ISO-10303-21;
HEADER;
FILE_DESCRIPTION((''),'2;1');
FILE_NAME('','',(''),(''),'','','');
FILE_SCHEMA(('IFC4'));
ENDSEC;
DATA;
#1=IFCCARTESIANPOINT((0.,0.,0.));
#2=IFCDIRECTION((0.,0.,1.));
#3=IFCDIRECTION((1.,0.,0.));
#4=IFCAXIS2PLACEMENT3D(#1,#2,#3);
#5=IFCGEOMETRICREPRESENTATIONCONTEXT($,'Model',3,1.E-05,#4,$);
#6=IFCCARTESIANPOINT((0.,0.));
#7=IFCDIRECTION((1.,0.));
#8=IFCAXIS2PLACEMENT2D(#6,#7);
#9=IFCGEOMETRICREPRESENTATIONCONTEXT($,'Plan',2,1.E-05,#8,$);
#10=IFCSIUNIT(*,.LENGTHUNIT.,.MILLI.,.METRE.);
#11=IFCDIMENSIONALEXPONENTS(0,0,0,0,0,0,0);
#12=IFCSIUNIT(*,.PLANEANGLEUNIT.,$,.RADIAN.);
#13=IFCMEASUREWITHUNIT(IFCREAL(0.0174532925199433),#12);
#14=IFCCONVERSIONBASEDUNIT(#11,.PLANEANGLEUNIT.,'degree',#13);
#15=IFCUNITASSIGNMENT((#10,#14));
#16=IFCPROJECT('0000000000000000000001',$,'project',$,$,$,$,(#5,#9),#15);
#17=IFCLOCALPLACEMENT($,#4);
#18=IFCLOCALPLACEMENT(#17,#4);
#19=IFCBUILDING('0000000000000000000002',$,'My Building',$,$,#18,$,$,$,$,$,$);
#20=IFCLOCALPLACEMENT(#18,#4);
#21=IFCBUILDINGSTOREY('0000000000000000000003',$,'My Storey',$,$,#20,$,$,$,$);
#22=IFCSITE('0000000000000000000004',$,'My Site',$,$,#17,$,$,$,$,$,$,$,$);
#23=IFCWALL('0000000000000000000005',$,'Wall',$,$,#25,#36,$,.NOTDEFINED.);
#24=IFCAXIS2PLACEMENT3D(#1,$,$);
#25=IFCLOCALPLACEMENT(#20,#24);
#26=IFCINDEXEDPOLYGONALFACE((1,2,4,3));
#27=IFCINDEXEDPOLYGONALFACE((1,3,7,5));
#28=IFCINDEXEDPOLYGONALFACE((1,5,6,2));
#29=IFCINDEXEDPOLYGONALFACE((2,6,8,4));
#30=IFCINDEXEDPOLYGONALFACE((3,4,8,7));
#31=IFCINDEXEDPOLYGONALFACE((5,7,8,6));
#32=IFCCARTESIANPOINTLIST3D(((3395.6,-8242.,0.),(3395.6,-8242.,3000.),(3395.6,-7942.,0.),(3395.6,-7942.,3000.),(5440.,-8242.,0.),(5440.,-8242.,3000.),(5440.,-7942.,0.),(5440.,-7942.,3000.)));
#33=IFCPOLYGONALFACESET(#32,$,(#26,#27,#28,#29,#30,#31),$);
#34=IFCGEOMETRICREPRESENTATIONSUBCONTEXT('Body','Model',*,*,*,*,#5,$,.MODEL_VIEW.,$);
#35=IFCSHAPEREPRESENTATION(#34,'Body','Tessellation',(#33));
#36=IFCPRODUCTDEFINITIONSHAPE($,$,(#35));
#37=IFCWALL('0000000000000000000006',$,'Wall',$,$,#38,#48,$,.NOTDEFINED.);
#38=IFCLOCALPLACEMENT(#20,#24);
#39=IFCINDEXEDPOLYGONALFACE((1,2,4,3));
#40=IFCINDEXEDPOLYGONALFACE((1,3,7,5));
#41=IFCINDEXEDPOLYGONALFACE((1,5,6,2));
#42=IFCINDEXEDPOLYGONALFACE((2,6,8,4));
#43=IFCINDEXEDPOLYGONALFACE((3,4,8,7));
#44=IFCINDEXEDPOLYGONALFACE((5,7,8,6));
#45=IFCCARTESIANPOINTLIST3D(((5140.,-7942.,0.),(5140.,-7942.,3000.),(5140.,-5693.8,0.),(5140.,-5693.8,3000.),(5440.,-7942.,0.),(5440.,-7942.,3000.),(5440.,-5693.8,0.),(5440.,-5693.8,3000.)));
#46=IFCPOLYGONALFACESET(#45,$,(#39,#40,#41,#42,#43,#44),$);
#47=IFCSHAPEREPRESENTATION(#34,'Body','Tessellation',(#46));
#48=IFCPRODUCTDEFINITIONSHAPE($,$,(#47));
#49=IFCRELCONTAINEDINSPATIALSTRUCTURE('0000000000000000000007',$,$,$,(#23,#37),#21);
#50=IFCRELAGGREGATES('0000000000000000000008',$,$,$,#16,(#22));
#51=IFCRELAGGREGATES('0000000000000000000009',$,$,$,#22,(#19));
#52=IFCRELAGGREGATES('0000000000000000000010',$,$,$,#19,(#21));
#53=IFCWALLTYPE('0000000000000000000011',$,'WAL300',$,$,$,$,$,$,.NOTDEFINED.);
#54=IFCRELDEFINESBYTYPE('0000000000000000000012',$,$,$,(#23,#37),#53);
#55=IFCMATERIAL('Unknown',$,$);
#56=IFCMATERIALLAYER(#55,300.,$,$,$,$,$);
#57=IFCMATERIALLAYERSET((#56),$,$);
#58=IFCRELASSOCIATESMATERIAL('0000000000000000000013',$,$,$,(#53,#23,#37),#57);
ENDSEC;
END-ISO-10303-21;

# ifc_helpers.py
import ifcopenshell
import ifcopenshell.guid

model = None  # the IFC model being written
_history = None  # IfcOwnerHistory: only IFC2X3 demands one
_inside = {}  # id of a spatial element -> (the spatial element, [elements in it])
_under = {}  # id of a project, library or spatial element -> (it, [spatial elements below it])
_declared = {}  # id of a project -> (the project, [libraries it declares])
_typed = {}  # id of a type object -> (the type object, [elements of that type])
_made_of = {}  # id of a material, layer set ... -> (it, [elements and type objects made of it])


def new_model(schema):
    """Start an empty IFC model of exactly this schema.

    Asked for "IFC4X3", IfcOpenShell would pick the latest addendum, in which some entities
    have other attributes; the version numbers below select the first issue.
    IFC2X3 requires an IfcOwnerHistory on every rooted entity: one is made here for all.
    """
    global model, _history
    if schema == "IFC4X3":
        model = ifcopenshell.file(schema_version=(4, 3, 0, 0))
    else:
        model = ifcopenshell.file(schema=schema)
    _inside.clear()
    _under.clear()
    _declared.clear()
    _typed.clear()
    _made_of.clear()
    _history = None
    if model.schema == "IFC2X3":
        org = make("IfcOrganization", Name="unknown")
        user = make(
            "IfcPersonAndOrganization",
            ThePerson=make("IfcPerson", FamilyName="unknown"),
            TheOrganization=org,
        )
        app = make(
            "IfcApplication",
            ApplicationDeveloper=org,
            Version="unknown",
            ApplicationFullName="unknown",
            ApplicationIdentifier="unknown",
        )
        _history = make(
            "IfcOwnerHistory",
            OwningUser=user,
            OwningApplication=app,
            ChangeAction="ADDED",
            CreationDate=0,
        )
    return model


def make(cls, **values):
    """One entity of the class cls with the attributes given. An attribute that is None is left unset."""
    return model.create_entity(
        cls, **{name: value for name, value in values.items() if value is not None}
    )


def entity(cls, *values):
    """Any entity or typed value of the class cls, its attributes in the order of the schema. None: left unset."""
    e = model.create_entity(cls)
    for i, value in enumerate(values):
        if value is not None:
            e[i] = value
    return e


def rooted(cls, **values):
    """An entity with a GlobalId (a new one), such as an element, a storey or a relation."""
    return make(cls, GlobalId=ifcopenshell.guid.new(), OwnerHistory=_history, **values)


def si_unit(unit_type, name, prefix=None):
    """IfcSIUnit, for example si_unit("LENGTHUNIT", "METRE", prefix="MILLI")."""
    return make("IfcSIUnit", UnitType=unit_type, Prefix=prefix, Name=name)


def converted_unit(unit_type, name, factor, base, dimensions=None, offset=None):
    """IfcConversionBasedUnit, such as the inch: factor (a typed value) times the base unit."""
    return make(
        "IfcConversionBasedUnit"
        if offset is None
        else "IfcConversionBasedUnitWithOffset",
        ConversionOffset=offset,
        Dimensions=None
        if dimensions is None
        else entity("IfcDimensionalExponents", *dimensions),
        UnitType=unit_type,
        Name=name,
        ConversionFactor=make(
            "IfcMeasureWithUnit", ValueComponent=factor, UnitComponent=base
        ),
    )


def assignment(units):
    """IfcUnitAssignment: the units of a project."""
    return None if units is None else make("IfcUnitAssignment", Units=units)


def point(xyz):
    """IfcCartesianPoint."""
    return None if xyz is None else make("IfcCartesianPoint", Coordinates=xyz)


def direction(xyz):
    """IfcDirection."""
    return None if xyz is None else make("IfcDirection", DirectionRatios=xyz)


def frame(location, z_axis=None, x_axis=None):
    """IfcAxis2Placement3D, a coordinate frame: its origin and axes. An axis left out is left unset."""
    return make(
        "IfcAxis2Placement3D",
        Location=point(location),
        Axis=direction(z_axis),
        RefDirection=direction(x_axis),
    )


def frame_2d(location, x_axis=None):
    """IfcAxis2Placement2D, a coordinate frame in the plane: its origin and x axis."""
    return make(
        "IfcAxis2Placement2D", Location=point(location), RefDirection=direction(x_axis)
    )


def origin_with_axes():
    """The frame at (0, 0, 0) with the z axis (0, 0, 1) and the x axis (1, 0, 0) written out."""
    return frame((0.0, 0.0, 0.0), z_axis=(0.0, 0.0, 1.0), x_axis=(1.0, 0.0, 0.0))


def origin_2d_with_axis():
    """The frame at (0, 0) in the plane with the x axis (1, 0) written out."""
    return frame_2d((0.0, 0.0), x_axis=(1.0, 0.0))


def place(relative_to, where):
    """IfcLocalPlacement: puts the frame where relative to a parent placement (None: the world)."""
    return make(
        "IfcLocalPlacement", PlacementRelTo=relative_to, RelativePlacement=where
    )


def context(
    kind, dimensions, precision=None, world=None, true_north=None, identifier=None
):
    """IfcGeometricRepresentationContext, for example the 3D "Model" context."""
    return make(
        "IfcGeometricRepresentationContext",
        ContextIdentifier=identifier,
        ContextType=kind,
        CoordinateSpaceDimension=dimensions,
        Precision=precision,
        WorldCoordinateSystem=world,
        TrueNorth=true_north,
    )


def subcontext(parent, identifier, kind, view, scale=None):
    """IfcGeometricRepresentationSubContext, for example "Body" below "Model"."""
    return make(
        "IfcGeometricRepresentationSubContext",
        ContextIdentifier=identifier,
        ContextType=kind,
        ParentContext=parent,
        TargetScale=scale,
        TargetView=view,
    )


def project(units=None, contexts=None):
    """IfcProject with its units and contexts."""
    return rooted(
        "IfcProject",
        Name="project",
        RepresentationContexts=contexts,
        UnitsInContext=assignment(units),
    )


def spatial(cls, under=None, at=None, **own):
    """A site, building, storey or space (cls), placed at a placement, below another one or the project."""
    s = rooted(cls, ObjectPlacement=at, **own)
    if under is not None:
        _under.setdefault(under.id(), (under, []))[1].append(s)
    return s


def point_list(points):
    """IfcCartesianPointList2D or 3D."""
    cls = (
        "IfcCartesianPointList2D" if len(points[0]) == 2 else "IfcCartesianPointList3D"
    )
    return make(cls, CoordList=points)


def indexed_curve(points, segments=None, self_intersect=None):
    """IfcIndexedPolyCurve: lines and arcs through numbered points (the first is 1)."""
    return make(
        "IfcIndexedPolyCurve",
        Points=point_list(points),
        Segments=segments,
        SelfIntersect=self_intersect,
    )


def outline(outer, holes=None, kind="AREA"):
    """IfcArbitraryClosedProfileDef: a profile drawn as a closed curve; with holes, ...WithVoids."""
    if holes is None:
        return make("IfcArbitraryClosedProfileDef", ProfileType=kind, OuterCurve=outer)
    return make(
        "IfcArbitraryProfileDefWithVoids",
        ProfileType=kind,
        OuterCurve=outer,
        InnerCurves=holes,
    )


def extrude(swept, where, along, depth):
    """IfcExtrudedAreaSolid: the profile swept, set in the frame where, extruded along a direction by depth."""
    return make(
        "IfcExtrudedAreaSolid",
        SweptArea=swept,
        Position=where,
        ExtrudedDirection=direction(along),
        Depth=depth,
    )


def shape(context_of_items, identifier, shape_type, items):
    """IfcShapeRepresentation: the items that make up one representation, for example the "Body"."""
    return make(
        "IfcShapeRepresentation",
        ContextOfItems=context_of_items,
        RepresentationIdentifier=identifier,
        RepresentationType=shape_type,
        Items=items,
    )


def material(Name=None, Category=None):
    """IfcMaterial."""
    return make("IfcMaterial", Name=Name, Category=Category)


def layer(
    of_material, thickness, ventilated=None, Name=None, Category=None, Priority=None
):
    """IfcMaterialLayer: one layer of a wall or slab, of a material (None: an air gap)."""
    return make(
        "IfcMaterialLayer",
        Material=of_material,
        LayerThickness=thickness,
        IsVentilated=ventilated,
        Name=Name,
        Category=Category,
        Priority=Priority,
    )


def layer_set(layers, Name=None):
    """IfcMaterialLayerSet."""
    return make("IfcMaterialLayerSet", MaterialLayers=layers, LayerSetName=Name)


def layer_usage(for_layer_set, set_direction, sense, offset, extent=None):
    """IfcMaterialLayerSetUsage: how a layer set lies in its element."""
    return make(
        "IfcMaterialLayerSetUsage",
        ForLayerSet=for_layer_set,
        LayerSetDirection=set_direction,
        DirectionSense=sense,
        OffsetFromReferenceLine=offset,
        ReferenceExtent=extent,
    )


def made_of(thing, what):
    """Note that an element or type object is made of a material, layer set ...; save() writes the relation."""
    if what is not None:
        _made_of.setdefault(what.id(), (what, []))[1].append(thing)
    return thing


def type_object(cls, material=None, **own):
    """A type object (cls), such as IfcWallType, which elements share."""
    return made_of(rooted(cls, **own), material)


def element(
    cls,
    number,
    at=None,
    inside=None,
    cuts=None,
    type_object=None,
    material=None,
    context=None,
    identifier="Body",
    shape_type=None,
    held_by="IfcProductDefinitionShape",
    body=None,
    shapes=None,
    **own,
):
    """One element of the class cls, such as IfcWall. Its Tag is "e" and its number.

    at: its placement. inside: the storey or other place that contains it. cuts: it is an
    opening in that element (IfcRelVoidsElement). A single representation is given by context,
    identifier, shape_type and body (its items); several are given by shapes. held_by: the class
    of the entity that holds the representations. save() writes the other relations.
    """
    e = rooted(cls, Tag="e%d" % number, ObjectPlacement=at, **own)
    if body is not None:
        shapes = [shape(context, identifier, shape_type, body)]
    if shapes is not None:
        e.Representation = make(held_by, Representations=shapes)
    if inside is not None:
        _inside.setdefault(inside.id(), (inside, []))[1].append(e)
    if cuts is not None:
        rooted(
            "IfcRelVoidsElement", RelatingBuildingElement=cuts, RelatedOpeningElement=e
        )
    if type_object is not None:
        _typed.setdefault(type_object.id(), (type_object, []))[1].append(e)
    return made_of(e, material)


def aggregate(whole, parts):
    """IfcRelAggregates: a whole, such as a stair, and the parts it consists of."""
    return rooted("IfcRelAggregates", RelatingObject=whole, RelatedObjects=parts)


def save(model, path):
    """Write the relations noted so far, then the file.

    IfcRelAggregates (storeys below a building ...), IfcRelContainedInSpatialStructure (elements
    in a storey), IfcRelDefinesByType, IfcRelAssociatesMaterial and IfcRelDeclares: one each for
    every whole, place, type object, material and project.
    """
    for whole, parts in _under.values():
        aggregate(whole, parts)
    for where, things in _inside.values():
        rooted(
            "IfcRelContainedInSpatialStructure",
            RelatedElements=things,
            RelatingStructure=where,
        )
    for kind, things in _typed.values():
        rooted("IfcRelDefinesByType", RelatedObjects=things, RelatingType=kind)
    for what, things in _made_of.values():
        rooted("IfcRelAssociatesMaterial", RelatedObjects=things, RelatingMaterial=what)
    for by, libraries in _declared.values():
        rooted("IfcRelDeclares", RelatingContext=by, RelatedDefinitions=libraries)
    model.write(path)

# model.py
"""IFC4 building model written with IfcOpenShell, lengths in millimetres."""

from ifc_helpers import new_model, entity, si_unit, converted_unit, frame, origin_with_axes, origin_2d_with_axis, place, context, subcontext, project, spatial, indexed_curve, outline, extrude, material, layer, layer_set, layer_usage, type_object, element, save


model = new_model("IFC4")

# Units and contexts
model_context = context("Model", 3, precision=1e-05, world=origin_with_axes())
plan_context = context("Plan", 2, precision=1e-05, world=origin_2d_with_axis())
body_context_1 = subcontext(model_context, "Body", "Model", "MODEL_VIEW")
ifc_project = project(units=[si_unit("LENGTHUNIT", "METRE", prefix="MILLI"), converted_unit("PLANEANGLEUNIT", "degree", entity("IfcReal", 0.0174532925199433), si_unit("PLANEANGLEUNIT", "RADIAN"), dimensions=[0, 0, 0, 0, 0, 0, 0])], contexts=[model_context, plan_context])

# Site, building, storey
site_placement = place(None, origin_with_axes())
site = spatial("IfcSite", under=ifc_project, at=site_placement, Name="My Site")
building_placement = place(site_placement, origin_with_axes())
building = spatial("IfcBuilding", under=site, at=building_placement, Name="My Building")
storey_placement = place(building_placement, origin_with_axes())
storey = spatial("IfcBuildingStorey", under=building, at=storey_placement, Name="My Storey")

# Shared definitions
ifc_material = material(Name="Unknown")

# Shared definitions
ifc_layer_1 = layer(ifc_material, 300.0)
ifc_layer_set_1 = layer_set([ifc_layer_1])
wall_type_1 = type_object("IfcWallType", Name="WAL300", PredefinedType="NOTDEFINED", material=ifc_layer_set_1)

# Walls
ifc_layer_usage_1 = layer_usage(ifc_layer_set_1, "AXIS2", "POSITIVE", 0.0)
wall_1_placement = place(storey_placement, frame((5440.0, -7942.0, 0.0), z_axis=(0.0, 0.0, 1.0), x_axis=(-1.0, 0.000002, 0.0)))
element("IfcWall", 1, at=wall_1_placement, inside=storey, type_object=wall_type_1, material=ifc_layer_usage_1, Name="Wall", PredefinedType="NOTDEFINED", context=body_context_1, shape_type="SweptSolid", body=[
    extrude(outline(indexed_curve([(0.0, 0.0), (0.0, 300.0), (2044.4, 300.0), (2044.4, 0.0), (0.0, 0.0)], self_intersect=False)), origin_with_axes(), (0.0, 0.0, 1.0), 3000.0),
])
ifc_layer_usage_2 = layer_usage(ifc_layer_set_1, "AXIS2", "POSITIVE", 0.0)
wall_2_placement = place(storey_placement, frame((5140.0, -5693.8, 0.0), z_axis=(0.0, 0.0, 1.0), x_axis=(-0.000001, -1.0, 0.0)))
element("IfcWall", 2, at=wall_2_placement, inside=storey, type_object=wall_type_1, material=ifc_layer_usage_2, Name="Wall", PredefinedType="NOTDEFINED", context=body_context_1, shape_type="SweptSolid", body=[
    extrude(outline(indexed_curve([(0.0, 0.0), (0.0, 300.0), (2248.1, 300.0), (2248.1, 0.0), (0.0, 0.0)], self_intersect=False)), origin_with_axes(), (0.0, 0.0, 1.0), 3000.0),
])

save(model, "model.ifc")
